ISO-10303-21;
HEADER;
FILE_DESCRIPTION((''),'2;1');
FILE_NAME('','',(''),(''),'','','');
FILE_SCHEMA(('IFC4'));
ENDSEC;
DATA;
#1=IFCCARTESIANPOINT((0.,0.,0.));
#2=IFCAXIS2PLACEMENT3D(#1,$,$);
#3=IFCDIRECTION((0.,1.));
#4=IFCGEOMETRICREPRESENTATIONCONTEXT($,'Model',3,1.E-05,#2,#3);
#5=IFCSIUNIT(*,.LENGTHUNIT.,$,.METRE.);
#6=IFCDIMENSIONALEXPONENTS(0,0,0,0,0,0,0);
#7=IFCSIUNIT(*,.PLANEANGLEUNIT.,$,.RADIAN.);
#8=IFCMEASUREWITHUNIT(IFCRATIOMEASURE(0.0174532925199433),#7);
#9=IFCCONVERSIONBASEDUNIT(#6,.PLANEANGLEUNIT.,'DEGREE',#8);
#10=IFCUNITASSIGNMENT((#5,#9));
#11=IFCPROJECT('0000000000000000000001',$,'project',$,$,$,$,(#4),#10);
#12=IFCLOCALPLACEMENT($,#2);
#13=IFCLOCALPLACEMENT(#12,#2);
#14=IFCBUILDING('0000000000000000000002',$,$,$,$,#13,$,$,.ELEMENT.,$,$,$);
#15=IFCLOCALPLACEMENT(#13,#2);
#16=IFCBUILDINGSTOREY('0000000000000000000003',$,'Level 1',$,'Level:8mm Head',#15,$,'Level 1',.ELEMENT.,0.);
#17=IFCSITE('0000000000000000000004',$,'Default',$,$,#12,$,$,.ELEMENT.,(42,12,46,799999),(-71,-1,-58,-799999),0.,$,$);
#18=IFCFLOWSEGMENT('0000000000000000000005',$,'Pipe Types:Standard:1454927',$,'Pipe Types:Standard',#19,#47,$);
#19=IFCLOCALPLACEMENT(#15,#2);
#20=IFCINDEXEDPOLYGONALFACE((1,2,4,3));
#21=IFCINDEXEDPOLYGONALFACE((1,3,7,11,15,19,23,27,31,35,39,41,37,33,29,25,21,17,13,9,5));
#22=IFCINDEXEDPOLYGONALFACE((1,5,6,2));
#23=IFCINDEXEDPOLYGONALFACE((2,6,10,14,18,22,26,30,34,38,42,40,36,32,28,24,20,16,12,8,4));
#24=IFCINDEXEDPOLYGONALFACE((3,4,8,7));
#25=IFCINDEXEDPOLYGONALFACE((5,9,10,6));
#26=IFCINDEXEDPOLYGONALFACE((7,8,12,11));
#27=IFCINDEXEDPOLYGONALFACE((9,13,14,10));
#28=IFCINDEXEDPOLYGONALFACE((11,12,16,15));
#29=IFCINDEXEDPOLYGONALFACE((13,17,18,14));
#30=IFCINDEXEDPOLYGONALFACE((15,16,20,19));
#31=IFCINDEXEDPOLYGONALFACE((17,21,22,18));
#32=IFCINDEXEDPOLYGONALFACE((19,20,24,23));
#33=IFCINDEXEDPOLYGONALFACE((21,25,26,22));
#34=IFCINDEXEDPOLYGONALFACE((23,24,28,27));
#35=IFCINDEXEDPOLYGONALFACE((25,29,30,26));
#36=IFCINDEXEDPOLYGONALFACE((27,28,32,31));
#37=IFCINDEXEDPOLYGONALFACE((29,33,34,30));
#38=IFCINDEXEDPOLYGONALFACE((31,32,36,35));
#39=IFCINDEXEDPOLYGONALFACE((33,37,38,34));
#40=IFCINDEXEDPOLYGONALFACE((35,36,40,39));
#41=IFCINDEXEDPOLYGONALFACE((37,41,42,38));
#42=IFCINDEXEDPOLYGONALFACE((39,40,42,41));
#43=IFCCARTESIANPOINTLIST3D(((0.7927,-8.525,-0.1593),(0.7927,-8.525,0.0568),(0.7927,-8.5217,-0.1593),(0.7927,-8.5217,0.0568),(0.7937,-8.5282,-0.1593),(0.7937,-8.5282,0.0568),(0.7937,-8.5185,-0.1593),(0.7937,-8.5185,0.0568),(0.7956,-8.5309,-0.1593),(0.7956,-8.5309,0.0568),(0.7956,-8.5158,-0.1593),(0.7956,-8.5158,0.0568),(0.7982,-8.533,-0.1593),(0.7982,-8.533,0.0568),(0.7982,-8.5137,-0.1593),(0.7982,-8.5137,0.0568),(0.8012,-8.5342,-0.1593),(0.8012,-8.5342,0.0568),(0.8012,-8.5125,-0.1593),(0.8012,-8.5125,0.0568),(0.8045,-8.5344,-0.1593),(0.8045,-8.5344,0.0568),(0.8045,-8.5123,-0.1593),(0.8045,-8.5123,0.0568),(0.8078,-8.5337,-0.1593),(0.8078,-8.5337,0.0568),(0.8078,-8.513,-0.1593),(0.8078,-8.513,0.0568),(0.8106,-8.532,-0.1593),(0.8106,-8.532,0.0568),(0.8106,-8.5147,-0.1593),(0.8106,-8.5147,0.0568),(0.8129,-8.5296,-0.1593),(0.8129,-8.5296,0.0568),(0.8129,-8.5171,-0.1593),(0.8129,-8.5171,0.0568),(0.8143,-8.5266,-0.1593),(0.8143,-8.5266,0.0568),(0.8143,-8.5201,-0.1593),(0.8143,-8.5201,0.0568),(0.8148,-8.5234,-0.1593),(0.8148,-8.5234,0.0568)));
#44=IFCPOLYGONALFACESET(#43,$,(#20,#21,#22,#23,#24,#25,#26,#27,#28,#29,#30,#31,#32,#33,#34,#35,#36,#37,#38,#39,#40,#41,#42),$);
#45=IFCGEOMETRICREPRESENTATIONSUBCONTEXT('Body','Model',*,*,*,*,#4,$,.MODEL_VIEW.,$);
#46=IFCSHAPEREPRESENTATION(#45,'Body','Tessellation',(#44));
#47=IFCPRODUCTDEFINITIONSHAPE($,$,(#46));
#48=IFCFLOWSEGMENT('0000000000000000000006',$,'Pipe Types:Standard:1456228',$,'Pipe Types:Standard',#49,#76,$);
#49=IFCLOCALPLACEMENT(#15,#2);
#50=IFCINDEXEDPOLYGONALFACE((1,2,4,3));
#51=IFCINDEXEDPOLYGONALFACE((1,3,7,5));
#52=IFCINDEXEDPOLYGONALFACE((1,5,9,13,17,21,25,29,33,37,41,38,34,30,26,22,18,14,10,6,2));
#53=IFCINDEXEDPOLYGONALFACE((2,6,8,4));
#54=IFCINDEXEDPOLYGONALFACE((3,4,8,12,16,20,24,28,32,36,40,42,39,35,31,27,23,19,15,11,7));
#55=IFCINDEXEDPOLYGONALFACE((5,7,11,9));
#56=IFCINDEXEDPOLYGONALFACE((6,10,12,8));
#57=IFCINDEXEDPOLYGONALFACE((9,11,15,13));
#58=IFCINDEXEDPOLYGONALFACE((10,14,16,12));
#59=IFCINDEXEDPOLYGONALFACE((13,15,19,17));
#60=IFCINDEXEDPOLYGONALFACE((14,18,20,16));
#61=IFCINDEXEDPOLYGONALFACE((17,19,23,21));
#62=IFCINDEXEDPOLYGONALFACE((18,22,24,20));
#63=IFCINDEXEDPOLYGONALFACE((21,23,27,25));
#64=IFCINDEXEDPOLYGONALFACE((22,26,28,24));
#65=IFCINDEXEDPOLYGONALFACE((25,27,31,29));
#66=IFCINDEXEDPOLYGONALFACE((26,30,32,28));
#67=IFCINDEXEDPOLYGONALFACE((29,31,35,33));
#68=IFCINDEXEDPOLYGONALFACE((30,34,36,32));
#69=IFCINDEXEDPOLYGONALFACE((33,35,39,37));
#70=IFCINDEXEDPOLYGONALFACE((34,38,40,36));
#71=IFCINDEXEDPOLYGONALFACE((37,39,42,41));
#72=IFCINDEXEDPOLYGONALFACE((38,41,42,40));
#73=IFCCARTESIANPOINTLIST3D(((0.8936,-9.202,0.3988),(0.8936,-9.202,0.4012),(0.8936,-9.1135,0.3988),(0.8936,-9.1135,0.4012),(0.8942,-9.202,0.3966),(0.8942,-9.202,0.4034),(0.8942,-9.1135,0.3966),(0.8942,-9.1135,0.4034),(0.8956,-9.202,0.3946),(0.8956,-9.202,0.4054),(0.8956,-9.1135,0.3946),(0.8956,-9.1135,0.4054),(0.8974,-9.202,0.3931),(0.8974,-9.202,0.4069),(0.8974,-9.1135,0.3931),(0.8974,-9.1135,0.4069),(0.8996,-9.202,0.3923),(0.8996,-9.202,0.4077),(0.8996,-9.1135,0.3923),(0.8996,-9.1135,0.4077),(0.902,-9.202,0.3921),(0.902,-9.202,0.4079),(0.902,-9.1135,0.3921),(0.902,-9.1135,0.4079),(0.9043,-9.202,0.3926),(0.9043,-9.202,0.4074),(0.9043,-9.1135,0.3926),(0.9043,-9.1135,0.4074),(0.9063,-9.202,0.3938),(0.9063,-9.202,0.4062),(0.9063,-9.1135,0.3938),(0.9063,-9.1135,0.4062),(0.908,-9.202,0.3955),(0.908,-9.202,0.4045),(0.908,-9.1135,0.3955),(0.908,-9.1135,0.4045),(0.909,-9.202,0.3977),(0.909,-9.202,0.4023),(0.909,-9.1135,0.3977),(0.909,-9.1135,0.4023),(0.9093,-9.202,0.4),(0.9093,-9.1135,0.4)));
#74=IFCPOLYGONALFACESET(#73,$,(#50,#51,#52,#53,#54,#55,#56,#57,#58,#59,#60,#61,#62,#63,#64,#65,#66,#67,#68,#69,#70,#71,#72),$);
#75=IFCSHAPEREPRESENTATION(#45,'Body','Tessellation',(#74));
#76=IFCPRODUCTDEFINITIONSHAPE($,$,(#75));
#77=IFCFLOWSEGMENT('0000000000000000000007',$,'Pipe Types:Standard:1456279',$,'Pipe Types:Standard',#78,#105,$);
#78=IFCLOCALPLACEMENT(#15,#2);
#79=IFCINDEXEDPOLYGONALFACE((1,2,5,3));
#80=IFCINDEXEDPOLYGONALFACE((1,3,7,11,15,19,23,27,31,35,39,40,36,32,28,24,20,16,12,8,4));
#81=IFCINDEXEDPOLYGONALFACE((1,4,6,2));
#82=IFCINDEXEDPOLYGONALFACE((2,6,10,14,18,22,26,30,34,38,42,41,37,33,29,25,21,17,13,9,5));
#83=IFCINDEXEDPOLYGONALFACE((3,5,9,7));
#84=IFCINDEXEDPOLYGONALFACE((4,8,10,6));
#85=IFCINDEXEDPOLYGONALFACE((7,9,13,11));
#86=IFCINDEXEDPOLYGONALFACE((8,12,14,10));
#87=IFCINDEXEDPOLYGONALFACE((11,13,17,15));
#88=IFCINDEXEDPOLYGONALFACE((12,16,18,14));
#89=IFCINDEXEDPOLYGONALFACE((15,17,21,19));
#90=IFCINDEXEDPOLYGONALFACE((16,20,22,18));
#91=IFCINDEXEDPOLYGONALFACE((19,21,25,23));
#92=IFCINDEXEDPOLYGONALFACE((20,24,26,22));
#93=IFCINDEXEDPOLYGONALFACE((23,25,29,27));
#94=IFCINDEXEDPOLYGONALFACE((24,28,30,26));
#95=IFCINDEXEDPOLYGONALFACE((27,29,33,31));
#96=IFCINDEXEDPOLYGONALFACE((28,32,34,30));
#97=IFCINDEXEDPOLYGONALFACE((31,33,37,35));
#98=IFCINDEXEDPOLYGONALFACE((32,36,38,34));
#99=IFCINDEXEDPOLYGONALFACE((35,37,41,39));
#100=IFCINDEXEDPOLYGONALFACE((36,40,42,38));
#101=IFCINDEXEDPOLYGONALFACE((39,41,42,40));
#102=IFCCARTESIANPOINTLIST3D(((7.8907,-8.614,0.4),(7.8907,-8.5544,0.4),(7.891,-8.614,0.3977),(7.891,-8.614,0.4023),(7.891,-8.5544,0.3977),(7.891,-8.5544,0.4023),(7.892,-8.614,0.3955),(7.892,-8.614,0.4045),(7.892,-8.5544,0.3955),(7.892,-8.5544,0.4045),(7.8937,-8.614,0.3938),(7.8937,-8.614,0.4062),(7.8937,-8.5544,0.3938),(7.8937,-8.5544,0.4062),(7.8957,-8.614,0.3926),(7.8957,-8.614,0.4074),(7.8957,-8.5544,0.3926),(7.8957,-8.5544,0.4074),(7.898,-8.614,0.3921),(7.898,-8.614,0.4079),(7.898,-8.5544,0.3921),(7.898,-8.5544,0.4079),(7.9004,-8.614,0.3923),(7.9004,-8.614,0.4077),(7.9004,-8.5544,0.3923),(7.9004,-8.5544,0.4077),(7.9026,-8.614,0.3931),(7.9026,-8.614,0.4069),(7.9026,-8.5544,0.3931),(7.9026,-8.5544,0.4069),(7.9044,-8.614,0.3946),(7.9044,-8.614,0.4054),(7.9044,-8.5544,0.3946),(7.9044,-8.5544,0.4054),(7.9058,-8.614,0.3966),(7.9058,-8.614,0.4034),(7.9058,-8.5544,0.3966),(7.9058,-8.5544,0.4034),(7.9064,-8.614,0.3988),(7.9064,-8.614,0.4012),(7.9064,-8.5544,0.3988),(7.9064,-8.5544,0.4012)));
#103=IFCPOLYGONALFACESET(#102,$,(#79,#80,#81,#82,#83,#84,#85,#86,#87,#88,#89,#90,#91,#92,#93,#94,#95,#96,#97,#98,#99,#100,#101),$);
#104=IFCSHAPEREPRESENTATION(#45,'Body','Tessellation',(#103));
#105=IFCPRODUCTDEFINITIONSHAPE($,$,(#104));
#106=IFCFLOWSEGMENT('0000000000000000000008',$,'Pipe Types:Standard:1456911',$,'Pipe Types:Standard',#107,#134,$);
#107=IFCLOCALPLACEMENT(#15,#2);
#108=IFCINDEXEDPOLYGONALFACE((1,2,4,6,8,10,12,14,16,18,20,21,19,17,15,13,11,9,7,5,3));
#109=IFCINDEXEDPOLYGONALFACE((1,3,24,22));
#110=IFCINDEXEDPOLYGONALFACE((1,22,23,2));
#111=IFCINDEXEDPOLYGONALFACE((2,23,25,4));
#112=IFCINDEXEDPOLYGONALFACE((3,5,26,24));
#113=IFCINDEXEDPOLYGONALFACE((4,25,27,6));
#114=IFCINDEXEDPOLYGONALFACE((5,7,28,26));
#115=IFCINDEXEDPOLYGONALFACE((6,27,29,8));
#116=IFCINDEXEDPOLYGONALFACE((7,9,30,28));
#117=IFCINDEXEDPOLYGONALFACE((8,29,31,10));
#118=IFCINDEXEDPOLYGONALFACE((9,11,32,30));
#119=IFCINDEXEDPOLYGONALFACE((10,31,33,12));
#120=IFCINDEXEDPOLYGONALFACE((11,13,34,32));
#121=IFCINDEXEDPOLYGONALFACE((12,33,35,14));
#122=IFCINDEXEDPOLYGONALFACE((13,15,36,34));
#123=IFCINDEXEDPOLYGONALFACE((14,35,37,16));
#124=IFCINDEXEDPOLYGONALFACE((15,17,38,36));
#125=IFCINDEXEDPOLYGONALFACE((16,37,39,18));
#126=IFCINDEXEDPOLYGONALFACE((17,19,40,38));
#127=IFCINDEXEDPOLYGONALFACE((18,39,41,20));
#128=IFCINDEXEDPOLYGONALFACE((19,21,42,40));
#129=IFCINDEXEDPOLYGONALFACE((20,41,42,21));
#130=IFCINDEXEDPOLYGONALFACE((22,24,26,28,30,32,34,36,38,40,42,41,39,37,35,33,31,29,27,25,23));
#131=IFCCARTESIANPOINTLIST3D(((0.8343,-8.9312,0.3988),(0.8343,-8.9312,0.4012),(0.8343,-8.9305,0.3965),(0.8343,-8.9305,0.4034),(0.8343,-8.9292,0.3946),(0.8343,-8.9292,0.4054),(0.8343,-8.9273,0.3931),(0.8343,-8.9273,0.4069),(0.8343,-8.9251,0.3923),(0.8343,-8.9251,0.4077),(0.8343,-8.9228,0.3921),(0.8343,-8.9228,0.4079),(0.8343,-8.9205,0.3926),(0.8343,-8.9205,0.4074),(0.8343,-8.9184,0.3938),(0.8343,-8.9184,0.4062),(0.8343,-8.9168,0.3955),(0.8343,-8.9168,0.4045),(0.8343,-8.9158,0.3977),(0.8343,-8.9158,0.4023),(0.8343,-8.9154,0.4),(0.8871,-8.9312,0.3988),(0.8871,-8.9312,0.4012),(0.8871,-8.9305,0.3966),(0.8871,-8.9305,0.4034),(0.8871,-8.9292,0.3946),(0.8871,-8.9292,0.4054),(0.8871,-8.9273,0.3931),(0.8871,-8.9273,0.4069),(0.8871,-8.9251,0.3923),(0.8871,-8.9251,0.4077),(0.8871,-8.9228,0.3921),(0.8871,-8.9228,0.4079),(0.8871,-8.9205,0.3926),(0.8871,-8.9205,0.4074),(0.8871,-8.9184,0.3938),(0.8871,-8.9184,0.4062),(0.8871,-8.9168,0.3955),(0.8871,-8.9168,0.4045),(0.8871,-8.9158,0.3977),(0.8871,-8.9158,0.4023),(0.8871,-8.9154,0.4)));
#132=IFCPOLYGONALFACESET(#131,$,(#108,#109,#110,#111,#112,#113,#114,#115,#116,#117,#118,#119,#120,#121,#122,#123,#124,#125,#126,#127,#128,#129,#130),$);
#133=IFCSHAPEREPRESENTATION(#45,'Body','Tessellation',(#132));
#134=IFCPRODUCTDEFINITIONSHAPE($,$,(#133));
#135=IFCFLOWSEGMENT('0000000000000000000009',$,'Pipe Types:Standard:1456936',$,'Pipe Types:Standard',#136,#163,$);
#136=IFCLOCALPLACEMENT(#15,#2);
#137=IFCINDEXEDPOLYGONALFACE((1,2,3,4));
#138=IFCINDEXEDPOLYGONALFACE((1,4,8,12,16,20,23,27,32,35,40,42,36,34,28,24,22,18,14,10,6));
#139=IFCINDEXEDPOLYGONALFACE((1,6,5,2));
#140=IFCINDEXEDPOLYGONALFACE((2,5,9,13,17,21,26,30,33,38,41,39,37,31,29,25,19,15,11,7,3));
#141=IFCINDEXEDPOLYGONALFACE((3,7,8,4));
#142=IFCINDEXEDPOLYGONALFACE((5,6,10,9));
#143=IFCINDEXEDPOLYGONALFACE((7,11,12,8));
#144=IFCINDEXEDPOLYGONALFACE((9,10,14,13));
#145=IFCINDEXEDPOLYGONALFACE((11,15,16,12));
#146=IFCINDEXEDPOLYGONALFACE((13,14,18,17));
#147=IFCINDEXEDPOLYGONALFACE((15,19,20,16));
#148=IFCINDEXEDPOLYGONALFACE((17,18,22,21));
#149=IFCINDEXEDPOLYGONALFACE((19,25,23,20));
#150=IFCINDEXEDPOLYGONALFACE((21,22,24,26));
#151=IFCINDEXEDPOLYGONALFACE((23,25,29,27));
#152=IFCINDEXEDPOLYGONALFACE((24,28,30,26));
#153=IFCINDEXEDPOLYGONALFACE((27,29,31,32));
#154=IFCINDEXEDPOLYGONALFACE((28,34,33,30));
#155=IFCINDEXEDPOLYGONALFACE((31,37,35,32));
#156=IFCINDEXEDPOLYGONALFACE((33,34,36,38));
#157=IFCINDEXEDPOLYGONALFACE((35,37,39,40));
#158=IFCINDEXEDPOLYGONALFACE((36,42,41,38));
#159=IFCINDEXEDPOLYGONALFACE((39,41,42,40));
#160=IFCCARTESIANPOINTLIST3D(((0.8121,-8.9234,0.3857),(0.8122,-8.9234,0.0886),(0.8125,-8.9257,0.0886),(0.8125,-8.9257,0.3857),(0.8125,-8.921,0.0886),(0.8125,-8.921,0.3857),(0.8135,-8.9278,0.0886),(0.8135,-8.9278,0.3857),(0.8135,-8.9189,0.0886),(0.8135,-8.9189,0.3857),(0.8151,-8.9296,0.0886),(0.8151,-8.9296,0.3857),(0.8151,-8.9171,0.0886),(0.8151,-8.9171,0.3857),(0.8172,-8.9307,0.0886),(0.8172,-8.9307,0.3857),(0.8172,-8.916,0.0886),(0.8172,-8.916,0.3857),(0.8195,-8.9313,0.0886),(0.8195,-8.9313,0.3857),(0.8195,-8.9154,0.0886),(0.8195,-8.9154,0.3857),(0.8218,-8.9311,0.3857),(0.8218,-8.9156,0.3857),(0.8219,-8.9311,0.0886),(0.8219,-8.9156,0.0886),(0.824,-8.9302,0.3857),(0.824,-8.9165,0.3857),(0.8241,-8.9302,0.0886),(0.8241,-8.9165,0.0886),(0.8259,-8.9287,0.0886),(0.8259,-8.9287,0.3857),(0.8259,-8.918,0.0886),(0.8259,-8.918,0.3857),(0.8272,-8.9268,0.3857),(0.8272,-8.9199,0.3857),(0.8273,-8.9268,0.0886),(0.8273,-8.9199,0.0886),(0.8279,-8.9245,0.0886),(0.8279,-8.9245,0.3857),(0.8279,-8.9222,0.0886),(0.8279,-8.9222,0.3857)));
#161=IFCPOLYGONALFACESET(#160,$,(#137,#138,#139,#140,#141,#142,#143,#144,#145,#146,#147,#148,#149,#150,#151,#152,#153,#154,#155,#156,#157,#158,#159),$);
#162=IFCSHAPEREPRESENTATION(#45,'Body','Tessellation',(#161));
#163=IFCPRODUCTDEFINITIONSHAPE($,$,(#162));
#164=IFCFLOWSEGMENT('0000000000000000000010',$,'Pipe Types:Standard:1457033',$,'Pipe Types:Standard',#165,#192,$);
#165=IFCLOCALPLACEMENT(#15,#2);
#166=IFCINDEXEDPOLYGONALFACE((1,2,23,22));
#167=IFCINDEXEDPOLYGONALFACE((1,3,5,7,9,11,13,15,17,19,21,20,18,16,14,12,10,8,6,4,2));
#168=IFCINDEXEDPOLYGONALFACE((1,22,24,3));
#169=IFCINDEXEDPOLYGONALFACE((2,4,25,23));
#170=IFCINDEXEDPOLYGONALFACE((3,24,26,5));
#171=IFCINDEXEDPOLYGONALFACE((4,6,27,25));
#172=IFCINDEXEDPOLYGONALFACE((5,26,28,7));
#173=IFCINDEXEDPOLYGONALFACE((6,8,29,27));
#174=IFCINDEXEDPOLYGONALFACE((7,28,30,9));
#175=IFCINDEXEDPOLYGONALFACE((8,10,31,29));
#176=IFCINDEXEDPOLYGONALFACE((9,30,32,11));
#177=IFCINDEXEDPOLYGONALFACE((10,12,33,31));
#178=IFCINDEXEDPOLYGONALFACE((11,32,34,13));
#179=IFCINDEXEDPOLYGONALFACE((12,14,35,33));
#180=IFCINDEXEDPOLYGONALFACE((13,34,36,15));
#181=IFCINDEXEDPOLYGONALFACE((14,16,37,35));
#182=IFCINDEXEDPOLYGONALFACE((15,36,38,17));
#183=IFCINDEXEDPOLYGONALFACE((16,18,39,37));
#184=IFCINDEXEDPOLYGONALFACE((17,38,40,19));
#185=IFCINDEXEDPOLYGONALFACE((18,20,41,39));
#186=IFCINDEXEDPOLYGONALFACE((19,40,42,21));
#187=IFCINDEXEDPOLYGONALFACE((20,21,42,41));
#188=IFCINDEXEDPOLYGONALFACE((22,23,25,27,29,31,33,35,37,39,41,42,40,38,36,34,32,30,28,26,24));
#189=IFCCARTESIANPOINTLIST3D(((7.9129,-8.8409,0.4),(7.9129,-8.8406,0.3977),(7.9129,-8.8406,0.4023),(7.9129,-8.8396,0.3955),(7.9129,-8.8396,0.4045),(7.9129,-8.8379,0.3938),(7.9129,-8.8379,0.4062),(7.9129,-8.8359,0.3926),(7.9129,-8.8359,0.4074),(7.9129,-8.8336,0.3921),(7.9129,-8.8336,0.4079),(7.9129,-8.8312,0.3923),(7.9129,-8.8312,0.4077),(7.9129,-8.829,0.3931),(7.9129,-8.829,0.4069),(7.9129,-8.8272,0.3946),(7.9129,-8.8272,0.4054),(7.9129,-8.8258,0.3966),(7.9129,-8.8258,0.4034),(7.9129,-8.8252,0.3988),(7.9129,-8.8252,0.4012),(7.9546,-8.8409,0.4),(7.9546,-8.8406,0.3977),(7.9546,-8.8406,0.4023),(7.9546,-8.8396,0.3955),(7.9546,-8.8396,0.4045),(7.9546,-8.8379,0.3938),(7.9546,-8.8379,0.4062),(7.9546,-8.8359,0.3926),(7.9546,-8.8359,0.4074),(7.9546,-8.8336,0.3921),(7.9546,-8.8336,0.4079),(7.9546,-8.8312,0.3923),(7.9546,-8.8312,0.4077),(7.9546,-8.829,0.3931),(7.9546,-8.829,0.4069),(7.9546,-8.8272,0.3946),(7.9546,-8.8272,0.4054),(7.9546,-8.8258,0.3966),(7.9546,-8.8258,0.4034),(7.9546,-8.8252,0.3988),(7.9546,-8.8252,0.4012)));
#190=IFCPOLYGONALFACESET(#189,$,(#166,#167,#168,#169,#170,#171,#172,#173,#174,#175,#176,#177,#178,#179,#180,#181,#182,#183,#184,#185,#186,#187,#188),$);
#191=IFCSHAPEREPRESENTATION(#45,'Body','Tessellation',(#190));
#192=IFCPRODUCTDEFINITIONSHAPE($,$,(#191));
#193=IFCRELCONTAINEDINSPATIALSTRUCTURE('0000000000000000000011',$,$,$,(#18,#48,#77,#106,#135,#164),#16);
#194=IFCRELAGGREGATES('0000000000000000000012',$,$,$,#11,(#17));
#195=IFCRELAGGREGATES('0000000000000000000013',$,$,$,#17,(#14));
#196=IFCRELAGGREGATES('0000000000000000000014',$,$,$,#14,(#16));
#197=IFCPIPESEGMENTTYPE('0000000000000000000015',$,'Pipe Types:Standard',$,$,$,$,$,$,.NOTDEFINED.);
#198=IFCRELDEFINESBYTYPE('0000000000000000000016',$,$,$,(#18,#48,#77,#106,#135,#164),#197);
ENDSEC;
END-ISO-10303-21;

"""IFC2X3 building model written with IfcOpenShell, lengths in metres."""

from ifc_helpers import new_model, entity, si_unit, converted_unit, direction, frame, frame_2d, origin, origin_2d_with_axis, place, context, subcontext, project, spatial, circle, extrude, type_object, element, save


model = new_model("IFC2X3")

# Units and contexts
model_context = context("Model", 3, precision=1e-05, world=origin(), true_north=direction((0.0, 1.0)))
body_context = subcontext(model_context, "Body", "Model", "MODEL_VIEW")
ifc_project = project(units=[si_unit("LENGTHUNIT", "METRE"), converted_unit("PLANEANGLEUNIT", "DEGREE", entity("IfcRatioMeasure", 0.0174532925199433), si_unit("PLANEANGLEUNIT", "RADIAN"), dimensions=[0, 0, 0, 0, 0, 0, 0])], contexts=[model_context])

# Site, building, storey
site_placement = place(None, origin())
site = spatial("IfcSite", under=ifc_project, at=site_placement, Name="Default", CompositionType="ELEMENT", RefLatitude=(42, 12, 46, 799999), RefLongitude=(-71, -1, -58, -799999), RefElevation=0.0)
building_placement = place(site_placement, origin())
building = spatial("IfcBuilding", under=site, at=building_placement, CompositionType="ELEMENT")
storey_placement = place(building_placement, origin())
storey = spatial("IfcBuildingStorey", under=building, at=storey_placement, Name="Level 1", ObjectType="Level:8mm Head", LongName="Level 1", CompositionType="ELEMENT", Elevation=0.0)

# Flow segments
pipe_segment_type = type_object("IfcPipeSegmentType", Name="Pipe Types:Standard", PredefinedType="NOTDEFINED")
flow_segment_1_placement = place(storey_placement, origin())
element("IfcFlowSegment", 1, at=flow_segment_1_placement, inside=storey, type_object=pipe_segment_type, Name="Pipe Types:Standard:1454927", ObjectType="Pipe Types:Standard", context=body_context, shape_type="SweptSolid", body=[
    extrude(circle(Radius=0.0111, at=frame_2d((0.0, 0.0), x_axis=(1.0, 0.0))), frame((0.8037, -8.5234, -0.1593)), (0.0, 0.0, 1.0), 0.2161),
])
flow_segment_2_placement = place(storey_placement, origin())
element("IfcFlowSegment", 2, at=flow_segment_2_placement, inside=storey, type_object=pipe_segment_type, Name="Pipe Types:Standard:1456228", ObjectType="Pipe Types:Standard", context=body_context, shape_type="SweptSolid", body=[
    extrude(circle(Radius=0.0079, at=frame_2d((0.0, 0.0), x_axis=(1.0, 0.0))), frame((0.9014, -9.202, 0.4), z_axis=(0.0, 1.0, 0.0), x_axis=(1.0, 0.0, 0.0)), (0.0, 0.0, 1.0), 0.0885),
])
flow_segment_3_placement = place(storey_placement, origin())
element("IfcFlowSegment", 3, at=flow_segment_3_placement, inside=storey, type_object=pipe_segment_type, Name="Pipe Types:Standard:1456279", ObjectType="Pipe Types:Standard", context=body_context, shape_type="SweptSolid", body=[
    extrude(circle(Radius=0.0079, at=frame_2d((0.0, 0.0), x_axis=(1.0, 0.0))), frame((7.8986, -8.614, 0.4), z_axis=(0.0, 1.0, 0.0), x_axis=(-1.0, 0.0, 0.0)), (0.0, 0.0, 1.0), 0.0596),
])
flow_segment_4_placement = place(storey_placement, origin())
element("IfcFlowSegment", 4, at=flow_segment_4_placement, inside=storey, type_object=pipe_segment_type, Name="Pipe Types:Standard:1456911", ObjectType="Pipe Types:Standard", context=body_context, shape_type="SweptSolid", body=[
    extrude(circle(Radius=0.0079, at=frame_2d((0.0, 0.0), x_axis=(1.0, 0.0))), frame((0.8343, -8.9234, 0.4), z_axis=(1.0, 0.0, 0.000113), x_axis=(0.0, 1.0, 0.0)), (0.0, 0.0, 1.0), 0.0528),
])
flow_segment_5_placement = place(storey_placement, origin())
element("IfcFlowSegment", 5, at=flow_segment_5_placement, inside=storey, type_object=pipe_segment_type, Name="Pipe Types:Standard:1456936", ObjectType="Pipe Types:Standard", context=body_context, shape_type="SweptSolid", body=[
    extrude(circle(Radius=0.0079, at=frame_2d((0.0, 0.0), x_axis=(1.0, 0.0))), frame((0.8201, -8.9234, 0.0886), z_axis=(-0.000144, 0.0, 1.0), x_axis=(-1.0, 0.0, -0.000144)), (0.0, 0.0, 1.0), 0.2971),
])
flow_segment_6_placement = place(storey_placement, origin())
element("IfcFlowSegment", 6, at=flow_segment_6_placement, inside=storey, type_object=pipe_segment_type, Name="Pipe Types:Standard:1457033", ObjectType="Pipe Types:Standard", context=body_context, shape_type="SweptSolid", body=[
    extrude(circle(Radius=0.0079, at=origin_2d_with_axis()), frame((7.9546, -8.833, 0.4), z_axis=(-1.0, 0.0, 0.000107), x_axis=(0.0, -1.0, 0.0)), (0.0, 0.0, 1.0), 0.0417),
])

save(model, "model.ifc")
